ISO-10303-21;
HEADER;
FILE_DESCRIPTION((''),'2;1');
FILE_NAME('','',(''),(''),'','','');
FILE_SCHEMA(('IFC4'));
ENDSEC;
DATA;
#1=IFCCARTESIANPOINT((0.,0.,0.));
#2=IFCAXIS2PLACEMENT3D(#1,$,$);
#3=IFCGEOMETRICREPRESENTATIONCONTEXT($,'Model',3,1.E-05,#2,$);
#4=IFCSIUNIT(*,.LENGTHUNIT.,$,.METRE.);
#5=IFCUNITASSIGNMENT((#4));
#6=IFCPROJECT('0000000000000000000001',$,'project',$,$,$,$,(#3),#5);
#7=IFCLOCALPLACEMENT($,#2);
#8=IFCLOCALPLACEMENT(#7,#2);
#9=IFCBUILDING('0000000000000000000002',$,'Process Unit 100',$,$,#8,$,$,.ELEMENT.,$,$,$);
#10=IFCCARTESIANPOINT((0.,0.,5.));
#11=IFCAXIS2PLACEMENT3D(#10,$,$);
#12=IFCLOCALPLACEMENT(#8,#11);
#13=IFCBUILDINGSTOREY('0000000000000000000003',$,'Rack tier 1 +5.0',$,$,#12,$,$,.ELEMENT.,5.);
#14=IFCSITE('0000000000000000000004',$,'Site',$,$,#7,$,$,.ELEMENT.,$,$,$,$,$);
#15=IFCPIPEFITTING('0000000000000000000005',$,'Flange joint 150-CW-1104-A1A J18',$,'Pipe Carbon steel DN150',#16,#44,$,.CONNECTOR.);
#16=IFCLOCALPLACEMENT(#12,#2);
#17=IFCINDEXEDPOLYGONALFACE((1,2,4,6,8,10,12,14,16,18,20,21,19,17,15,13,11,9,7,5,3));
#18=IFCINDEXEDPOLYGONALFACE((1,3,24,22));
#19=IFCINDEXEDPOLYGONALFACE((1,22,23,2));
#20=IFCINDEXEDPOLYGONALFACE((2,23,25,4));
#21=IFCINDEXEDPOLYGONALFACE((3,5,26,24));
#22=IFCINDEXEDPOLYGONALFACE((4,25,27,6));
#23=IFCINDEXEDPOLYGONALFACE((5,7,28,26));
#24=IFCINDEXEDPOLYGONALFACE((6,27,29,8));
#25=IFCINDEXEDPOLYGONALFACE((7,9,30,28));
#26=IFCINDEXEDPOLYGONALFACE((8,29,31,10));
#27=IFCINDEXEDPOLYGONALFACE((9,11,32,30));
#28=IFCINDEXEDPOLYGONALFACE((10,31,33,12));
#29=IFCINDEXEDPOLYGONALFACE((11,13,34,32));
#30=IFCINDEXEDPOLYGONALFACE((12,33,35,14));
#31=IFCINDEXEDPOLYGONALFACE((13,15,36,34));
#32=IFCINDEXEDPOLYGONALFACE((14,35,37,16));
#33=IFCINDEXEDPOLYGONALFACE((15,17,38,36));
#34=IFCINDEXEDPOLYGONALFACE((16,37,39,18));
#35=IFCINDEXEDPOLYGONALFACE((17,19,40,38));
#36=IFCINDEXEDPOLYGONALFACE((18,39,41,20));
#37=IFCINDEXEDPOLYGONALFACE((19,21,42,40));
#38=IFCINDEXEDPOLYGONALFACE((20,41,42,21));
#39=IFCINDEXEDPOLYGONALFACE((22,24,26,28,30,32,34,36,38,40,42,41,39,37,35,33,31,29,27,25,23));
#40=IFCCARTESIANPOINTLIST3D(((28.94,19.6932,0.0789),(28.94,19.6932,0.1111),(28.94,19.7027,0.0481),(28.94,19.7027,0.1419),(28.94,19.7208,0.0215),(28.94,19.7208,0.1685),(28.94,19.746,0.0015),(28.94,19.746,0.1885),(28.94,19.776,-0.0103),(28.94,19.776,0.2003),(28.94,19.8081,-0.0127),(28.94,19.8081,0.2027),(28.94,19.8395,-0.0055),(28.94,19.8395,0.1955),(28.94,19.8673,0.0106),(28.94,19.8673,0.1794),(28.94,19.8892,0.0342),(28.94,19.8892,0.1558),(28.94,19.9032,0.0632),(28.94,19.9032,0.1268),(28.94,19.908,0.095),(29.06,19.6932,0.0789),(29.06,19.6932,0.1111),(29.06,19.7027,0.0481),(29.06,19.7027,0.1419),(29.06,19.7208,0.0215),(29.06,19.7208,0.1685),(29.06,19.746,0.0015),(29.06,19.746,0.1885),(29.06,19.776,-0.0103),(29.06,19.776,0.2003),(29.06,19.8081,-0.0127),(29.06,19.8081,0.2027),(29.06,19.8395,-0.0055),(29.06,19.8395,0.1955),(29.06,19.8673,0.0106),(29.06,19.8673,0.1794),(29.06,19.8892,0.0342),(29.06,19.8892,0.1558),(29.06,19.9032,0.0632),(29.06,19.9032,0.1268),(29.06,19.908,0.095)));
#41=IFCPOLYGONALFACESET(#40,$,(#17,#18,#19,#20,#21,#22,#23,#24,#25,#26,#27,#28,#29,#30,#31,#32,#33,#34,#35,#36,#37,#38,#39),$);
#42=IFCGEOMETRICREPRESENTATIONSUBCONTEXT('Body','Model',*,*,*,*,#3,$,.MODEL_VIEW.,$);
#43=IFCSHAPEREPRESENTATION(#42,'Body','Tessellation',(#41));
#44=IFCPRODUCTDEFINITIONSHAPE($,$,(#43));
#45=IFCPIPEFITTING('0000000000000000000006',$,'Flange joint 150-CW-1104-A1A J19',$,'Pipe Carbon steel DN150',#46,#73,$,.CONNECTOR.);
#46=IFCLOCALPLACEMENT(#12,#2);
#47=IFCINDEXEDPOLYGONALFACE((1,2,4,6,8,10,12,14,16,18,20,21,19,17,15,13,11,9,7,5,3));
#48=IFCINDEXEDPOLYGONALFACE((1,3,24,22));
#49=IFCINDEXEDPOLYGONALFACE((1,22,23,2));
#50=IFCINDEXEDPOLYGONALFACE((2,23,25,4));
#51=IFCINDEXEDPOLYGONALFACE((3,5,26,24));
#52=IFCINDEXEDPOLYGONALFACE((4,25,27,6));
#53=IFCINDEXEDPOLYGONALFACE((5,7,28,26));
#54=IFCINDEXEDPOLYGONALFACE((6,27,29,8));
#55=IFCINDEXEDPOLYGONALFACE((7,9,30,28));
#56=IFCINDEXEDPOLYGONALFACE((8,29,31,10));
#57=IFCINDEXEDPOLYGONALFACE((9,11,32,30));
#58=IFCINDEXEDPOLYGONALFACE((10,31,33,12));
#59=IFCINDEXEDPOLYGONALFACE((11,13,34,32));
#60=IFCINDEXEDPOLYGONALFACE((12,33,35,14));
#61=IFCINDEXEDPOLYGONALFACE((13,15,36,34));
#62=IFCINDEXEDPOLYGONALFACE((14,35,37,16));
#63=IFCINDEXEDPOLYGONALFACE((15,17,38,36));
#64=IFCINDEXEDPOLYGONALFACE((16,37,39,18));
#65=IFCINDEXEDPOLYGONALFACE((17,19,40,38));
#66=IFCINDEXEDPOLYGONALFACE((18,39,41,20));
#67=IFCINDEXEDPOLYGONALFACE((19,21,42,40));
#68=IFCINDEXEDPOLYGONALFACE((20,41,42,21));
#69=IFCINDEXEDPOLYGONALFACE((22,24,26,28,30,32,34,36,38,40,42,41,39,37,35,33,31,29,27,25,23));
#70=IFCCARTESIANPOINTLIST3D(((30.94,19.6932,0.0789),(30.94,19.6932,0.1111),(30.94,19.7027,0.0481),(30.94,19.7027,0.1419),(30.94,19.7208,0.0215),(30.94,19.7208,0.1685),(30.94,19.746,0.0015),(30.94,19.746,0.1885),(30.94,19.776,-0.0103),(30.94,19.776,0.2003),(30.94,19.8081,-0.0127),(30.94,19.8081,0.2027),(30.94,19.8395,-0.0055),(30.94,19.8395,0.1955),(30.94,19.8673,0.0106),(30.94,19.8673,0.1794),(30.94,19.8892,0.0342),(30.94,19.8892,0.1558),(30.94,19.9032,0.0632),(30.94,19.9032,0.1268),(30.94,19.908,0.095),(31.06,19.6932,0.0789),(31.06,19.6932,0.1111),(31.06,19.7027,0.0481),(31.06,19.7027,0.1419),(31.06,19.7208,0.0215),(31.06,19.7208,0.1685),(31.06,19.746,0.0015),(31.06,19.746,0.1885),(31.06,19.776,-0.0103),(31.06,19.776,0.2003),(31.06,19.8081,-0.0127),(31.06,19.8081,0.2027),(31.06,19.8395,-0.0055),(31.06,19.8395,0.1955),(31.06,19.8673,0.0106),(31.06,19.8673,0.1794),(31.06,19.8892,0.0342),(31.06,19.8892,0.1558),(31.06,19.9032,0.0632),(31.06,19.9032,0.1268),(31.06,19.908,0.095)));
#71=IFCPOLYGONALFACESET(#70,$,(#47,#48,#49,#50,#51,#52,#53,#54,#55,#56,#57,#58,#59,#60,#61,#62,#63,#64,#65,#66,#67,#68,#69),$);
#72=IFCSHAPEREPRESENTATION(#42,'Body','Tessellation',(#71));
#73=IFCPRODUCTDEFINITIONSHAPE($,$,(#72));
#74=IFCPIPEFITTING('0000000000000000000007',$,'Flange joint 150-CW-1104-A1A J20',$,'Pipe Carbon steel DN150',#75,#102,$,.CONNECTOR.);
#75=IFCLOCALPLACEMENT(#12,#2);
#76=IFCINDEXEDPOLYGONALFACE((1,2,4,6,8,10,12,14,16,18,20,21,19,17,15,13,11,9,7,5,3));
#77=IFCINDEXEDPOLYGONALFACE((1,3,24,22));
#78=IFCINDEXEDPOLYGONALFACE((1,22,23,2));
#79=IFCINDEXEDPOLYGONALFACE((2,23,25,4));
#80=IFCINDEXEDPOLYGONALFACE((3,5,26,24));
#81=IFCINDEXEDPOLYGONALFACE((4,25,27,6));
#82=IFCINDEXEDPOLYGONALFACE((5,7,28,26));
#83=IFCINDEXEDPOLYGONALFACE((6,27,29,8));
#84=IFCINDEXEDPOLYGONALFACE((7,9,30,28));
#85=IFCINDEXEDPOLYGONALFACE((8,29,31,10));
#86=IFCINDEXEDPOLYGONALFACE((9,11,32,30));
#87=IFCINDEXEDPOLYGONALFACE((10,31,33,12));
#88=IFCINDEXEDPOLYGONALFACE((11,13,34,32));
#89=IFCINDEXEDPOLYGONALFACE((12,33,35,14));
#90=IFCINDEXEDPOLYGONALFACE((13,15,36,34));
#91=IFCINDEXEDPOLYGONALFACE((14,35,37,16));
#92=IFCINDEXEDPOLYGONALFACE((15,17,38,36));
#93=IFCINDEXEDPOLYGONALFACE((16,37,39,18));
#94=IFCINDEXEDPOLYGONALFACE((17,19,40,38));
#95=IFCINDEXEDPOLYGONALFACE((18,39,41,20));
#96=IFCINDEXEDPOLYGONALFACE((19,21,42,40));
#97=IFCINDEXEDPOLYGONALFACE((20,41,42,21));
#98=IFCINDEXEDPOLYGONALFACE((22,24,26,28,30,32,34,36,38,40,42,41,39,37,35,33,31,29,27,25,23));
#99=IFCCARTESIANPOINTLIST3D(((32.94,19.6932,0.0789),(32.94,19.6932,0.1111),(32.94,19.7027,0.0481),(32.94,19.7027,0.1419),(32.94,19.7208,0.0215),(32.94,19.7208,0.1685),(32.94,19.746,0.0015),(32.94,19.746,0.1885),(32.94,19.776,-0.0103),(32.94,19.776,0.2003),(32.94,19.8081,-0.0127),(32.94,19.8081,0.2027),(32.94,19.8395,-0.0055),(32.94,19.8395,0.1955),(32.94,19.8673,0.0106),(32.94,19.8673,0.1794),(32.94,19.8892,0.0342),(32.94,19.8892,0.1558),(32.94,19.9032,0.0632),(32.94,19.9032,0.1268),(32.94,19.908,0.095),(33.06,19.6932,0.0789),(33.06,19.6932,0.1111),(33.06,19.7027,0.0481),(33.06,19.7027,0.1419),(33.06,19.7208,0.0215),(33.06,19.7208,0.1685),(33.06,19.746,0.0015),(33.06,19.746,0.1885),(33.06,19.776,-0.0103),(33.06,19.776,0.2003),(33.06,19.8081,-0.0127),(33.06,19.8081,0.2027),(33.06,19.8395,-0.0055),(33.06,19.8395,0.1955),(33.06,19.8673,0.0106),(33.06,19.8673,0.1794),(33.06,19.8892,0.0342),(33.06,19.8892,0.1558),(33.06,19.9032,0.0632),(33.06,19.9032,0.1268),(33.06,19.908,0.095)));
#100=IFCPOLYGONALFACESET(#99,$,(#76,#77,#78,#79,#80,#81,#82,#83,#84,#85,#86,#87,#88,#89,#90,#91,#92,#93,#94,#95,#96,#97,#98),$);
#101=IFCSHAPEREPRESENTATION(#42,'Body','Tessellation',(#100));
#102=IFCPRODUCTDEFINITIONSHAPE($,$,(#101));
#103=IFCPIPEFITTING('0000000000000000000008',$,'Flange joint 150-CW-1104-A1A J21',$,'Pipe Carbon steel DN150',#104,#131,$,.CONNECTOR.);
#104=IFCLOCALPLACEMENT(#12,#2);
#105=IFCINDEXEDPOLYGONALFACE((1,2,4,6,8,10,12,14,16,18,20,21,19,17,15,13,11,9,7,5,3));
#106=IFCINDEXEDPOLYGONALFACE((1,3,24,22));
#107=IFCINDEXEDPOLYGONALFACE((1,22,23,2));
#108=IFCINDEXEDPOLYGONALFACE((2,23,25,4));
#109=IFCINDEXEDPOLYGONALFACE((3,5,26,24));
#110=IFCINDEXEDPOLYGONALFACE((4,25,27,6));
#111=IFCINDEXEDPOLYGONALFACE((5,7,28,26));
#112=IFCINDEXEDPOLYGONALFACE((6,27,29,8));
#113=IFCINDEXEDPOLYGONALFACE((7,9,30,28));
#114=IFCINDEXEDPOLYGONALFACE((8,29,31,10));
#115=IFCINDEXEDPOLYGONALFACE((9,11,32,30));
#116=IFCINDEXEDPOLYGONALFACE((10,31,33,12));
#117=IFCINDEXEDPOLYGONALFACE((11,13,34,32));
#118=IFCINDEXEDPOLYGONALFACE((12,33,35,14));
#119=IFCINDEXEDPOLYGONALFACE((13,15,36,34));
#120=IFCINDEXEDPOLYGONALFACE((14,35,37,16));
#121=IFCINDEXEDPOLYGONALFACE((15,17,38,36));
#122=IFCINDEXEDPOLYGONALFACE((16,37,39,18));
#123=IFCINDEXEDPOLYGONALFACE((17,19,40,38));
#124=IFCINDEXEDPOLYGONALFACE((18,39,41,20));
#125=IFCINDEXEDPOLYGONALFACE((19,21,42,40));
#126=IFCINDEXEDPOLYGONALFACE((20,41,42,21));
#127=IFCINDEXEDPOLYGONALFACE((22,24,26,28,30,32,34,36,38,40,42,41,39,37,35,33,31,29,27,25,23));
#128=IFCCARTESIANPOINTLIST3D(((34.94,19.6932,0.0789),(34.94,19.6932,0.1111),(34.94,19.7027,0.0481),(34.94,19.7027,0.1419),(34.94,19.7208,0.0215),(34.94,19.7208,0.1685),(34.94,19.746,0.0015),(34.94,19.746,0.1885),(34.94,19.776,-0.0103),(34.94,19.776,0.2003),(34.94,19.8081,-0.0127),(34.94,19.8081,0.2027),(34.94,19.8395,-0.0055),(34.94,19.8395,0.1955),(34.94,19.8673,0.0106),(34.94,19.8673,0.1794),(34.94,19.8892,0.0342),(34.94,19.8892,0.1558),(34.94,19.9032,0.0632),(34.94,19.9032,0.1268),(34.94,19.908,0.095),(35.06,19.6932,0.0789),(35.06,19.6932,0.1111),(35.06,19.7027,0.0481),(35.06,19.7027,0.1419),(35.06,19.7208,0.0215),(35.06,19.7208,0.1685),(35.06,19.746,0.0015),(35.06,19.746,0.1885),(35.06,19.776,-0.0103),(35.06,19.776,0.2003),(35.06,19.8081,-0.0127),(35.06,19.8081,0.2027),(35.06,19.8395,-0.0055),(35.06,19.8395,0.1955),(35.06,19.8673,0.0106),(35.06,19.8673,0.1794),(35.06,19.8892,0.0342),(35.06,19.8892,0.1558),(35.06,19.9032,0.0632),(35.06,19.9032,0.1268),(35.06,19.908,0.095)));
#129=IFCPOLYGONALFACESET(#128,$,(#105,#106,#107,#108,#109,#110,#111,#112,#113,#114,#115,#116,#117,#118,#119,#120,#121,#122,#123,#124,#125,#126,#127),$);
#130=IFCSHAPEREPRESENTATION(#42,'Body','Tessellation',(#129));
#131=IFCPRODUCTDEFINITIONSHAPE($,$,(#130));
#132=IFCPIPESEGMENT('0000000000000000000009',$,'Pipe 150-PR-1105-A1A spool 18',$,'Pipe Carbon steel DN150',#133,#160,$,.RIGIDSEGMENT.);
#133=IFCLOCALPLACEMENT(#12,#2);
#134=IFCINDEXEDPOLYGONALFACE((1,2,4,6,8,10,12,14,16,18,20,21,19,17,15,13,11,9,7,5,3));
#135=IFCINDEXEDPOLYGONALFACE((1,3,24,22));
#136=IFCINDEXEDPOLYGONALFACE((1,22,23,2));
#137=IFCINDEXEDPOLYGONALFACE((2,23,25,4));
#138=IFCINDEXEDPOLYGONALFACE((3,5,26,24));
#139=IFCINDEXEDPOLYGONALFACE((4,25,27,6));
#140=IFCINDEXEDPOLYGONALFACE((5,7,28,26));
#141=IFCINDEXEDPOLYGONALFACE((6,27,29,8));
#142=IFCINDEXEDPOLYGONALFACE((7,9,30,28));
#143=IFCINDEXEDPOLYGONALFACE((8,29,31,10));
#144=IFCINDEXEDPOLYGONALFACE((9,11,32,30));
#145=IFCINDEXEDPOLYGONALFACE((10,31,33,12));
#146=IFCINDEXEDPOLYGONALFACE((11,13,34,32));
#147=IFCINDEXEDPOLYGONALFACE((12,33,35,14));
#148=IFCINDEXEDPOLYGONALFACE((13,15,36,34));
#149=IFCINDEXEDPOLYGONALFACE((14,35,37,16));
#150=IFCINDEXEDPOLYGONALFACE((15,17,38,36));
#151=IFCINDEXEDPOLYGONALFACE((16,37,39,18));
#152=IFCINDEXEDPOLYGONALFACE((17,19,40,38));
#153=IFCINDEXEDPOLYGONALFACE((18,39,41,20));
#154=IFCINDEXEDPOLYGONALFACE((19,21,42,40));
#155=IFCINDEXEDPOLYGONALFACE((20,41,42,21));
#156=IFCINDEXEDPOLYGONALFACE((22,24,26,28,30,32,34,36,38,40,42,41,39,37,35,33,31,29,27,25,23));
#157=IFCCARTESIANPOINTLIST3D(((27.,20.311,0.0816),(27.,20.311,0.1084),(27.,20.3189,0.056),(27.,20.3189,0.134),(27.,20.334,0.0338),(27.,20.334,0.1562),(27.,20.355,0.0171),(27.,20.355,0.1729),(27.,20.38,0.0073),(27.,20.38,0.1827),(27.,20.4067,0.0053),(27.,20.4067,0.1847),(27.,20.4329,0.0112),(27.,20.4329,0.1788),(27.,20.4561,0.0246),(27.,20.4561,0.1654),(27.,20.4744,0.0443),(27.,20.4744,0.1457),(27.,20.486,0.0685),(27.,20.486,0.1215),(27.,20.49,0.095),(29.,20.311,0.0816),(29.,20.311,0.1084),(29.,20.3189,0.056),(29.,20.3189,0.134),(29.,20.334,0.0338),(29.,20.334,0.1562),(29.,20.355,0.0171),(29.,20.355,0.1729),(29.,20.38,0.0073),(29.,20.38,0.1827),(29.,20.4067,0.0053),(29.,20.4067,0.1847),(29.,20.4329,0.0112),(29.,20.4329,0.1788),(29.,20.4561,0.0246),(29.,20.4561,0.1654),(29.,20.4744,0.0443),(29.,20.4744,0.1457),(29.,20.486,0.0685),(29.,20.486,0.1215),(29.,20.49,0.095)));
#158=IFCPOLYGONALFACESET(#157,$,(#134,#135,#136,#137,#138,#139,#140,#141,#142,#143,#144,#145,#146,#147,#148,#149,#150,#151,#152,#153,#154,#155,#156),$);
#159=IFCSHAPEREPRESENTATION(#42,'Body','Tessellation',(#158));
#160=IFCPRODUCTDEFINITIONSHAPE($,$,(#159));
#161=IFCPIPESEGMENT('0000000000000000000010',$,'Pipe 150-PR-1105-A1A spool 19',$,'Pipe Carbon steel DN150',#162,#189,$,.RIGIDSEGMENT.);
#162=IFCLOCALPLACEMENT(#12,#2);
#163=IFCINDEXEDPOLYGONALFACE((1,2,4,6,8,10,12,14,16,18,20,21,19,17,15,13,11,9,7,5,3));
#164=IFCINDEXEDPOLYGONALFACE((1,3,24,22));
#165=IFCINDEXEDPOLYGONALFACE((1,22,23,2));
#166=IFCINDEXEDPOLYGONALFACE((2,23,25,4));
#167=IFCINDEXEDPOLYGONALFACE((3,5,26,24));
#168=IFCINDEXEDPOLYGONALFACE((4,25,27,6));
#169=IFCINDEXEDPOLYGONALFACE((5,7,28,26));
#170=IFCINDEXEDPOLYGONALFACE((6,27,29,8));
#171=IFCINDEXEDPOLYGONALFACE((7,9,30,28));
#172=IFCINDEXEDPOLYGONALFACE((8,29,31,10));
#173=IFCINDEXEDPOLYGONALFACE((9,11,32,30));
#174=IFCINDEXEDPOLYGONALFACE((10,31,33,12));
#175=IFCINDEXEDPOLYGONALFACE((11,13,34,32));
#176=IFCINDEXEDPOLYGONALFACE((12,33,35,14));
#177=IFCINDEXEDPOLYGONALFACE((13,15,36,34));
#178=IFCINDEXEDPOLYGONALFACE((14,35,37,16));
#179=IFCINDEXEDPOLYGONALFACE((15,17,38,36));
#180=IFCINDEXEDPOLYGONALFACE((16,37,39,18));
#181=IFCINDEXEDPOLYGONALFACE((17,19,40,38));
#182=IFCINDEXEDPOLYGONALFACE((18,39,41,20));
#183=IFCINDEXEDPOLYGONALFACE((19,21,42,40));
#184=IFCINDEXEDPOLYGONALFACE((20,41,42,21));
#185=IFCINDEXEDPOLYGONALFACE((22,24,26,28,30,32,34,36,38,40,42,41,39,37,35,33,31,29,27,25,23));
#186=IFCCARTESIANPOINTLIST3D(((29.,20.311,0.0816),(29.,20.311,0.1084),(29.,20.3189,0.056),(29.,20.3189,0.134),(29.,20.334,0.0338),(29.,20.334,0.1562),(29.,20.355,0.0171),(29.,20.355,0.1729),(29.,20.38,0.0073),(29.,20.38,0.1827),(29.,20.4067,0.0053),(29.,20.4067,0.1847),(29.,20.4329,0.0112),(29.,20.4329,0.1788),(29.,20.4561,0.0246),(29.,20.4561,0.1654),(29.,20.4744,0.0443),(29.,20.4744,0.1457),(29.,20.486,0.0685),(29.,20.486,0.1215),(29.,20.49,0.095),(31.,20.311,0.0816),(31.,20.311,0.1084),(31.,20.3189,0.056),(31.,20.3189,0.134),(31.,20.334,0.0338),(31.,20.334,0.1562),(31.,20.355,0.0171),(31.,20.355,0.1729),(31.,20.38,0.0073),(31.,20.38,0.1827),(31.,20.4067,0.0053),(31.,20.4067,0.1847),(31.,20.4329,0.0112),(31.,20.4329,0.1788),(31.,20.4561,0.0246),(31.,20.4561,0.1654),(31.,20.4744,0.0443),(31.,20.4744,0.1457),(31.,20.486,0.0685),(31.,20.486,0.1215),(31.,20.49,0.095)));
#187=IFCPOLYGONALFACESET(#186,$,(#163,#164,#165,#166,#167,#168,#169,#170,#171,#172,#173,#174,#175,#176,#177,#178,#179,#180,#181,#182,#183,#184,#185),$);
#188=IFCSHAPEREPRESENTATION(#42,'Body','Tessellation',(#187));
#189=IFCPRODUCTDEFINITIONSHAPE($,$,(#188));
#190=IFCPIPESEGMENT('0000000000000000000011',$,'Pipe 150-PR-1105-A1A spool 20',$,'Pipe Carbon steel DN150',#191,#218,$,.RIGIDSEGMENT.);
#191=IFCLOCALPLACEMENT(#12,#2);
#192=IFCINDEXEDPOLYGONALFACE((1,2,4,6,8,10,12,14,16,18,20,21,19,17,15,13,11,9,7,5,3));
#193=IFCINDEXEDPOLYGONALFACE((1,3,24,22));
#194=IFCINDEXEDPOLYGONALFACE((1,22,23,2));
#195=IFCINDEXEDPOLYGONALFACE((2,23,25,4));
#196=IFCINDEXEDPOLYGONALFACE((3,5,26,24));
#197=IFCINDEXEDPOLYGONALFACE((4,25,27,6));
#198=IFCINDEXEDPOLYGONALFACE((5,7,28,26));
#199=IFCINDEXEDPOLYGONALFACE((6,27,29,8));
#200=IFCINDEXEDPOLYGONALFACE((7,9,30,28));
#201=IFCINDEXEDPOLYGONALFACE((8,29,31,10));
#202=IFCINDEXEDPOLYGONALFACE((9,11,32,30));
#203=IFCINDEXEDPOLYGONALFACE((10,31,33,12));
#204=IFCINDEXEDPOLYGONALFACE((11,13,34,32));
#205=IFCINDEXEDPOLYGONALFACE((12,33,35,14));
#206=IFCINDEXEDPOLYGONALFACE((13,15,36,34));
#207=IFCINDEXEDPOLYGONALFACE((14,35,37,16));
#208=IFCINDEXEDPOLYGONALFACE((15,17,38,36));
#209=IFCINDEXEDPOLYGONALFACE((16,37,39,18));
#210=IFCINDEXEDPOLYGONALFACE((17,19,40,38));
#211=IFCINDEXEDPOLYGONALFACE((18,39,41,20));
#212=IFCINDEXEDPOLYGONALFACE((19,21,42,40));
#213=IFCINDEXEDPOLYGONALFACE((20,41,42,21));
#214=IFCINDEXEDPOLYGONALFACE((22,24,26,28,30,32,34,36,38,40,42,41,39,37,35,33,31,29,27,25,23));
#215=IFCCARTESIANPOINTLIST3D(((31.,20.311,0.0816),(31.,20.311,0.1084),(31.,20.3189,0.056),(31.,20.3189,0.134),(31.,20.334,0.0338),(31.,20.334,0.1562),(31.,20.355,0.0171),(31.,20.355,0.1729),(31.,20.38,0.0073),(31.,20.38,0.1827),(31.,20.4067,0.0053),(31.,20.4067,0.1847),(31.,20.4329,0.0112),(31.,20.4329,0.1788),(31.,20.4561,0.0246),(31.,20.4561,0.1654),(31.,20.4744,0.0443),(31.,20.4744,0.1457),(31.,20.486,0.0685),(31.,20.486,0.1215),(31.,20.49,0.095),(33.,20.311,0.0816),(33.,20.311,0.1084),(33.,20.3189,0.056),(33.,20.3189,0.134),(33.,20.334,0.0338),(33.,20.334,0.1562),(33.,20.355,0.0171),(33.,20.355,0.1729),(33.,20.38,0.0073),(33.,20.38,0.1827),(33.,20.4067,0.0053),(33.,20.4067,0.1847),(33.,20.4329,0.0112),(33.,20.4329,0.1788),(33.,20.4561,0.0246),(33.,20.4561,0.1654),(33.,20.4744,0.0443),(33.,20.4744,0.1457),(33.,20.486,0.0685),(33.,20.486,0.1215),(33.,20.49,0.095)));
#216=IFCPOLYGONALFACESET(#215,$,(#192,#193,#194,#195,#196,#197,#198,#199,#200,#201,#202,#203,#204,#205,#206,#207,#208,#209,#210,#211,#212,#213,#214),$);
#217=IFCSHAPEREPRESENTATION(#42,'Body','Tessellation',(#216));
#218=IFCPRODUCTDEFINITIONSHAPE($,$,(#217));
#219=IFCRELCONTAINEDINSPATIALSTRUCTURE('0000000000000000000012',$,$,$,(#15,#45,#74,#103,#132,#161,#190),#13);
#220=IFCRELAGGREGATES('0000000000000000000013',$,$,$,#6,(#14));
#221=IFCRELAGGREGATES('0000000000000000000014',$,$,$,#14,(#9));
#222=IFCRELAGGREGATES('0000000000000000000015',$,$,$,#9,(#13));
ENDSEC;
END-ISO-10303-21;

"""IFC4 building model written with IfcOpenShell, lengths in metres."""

from ifc_helpers import new_model, si_unit, frame, origin, place, context, subcontext, project, spatial, circle, extrude, element, save


model = new_model("IFC4")

# Units and contexts
model_context = context("Model", 3, precision=1e-05, world=origin())
body_context = subcontext(model_context, "Body", "Model", "MODEL_VIEW")
ifc_project = project(units=[si_unit("LENGTHUNIT", "METRE")], contexts=[model_context])

# Site, building, storey
site_placement = place(None, origin())
site = spatial("IfcSite", under=ifc_project, at=site_placement, Name="Site", CompositionType="ELEMENT")
building_placement = place(site_placement, origin())
building = spatial("IfcBuilding", under=site, at=building_placement, Name="Process Unit 100", CompositionType="ELEMENT")
storey_placement = place(building_placement, frame((0.0, 0.0, 5.0)))
storey = spatial("IfcBuildingStorey", under=building, at=storey_placement, Name="Rack tier 1 +5.0", CompositionType="ELEMENT", Elevation=5.0)

# Pipe fittings
for number, where, z_axis, x_axis, name in (
    (1, (28.94, 19.8, 0.095), (1.0, 0.0, 0.0), (0.0, 1.0, 0.0), "Flange joint 150-CW-1104-A1A J18"),
    (2, (30.94, 19.8, 0.095), (1.0, 0.0, 0.0), (0.0, 1.0, 0.0), "Flange joint 150-CW-1104-A1A J19"),
    (3, (32.94, 19.8, 0.095), (1.0, 0.0, 0.0), (0.0, 1.0, 0.0), "Flange joint 150-CW-1104-A1A J20"),
    (4, (34.94, 19.8, 0.095), (1.0, 0.0, 0.0), (0.0, 1.0, 0.0), "Flange joint 150-CW-1104-A1A J21"),
):
    element("IfcPipeFitting", number, at=place(storey_placement, frame(where, z_axis=z_axis, x_axis=x_axis)), inside=storey, Name=name, ObjectType="Pipe Carbon steel DN150", PredefinedType="CONNECTOR", context=body_context, shape_type="SweptSolid", body=[
        extrude(circle(Radius=0.108), origin(), (0.0, 0.0, 1.0), 0.12),
    ])

# Pipe segments
for number, where, z_axis, x_axis, name in (
    (5, (27.0, 20.4, 0.095), (1.0, 0.0, 0.0), (0.0, 1.0, 0.0), "Pipe 150-PR-1105-A1A spool 18"),
    (6, (29.0, 20.4, 0.095), (1.0, 0.0, 0.0), (0.0, 1.0, 0.0), "Pipe 150-PR-1105-A1A spool 19"),
    (7, (31.0, 20.4, 0.095), (1.0, 0.0, 0.0), (0.0, 1.0, 0.0), "Pipe 150-PR-1105-A1A spool 20"),
):
    element("IfcPipeSegment", number, at=place(storey_placement, frame(where, z_axis=z_axis, x_axis=x_axis)), inside=storey, Name=name, ObjectType="Pipe Carbon steel DN150", PredefinedType="RIGIDSEGMENT", context=body_context, shape_type="SweptSolid", body=[
        extrude(circle(Radius=0.09), origin(), (0.0, 0.0, 1.0), 2.0),
    ])

save(model, "model.ifc")
